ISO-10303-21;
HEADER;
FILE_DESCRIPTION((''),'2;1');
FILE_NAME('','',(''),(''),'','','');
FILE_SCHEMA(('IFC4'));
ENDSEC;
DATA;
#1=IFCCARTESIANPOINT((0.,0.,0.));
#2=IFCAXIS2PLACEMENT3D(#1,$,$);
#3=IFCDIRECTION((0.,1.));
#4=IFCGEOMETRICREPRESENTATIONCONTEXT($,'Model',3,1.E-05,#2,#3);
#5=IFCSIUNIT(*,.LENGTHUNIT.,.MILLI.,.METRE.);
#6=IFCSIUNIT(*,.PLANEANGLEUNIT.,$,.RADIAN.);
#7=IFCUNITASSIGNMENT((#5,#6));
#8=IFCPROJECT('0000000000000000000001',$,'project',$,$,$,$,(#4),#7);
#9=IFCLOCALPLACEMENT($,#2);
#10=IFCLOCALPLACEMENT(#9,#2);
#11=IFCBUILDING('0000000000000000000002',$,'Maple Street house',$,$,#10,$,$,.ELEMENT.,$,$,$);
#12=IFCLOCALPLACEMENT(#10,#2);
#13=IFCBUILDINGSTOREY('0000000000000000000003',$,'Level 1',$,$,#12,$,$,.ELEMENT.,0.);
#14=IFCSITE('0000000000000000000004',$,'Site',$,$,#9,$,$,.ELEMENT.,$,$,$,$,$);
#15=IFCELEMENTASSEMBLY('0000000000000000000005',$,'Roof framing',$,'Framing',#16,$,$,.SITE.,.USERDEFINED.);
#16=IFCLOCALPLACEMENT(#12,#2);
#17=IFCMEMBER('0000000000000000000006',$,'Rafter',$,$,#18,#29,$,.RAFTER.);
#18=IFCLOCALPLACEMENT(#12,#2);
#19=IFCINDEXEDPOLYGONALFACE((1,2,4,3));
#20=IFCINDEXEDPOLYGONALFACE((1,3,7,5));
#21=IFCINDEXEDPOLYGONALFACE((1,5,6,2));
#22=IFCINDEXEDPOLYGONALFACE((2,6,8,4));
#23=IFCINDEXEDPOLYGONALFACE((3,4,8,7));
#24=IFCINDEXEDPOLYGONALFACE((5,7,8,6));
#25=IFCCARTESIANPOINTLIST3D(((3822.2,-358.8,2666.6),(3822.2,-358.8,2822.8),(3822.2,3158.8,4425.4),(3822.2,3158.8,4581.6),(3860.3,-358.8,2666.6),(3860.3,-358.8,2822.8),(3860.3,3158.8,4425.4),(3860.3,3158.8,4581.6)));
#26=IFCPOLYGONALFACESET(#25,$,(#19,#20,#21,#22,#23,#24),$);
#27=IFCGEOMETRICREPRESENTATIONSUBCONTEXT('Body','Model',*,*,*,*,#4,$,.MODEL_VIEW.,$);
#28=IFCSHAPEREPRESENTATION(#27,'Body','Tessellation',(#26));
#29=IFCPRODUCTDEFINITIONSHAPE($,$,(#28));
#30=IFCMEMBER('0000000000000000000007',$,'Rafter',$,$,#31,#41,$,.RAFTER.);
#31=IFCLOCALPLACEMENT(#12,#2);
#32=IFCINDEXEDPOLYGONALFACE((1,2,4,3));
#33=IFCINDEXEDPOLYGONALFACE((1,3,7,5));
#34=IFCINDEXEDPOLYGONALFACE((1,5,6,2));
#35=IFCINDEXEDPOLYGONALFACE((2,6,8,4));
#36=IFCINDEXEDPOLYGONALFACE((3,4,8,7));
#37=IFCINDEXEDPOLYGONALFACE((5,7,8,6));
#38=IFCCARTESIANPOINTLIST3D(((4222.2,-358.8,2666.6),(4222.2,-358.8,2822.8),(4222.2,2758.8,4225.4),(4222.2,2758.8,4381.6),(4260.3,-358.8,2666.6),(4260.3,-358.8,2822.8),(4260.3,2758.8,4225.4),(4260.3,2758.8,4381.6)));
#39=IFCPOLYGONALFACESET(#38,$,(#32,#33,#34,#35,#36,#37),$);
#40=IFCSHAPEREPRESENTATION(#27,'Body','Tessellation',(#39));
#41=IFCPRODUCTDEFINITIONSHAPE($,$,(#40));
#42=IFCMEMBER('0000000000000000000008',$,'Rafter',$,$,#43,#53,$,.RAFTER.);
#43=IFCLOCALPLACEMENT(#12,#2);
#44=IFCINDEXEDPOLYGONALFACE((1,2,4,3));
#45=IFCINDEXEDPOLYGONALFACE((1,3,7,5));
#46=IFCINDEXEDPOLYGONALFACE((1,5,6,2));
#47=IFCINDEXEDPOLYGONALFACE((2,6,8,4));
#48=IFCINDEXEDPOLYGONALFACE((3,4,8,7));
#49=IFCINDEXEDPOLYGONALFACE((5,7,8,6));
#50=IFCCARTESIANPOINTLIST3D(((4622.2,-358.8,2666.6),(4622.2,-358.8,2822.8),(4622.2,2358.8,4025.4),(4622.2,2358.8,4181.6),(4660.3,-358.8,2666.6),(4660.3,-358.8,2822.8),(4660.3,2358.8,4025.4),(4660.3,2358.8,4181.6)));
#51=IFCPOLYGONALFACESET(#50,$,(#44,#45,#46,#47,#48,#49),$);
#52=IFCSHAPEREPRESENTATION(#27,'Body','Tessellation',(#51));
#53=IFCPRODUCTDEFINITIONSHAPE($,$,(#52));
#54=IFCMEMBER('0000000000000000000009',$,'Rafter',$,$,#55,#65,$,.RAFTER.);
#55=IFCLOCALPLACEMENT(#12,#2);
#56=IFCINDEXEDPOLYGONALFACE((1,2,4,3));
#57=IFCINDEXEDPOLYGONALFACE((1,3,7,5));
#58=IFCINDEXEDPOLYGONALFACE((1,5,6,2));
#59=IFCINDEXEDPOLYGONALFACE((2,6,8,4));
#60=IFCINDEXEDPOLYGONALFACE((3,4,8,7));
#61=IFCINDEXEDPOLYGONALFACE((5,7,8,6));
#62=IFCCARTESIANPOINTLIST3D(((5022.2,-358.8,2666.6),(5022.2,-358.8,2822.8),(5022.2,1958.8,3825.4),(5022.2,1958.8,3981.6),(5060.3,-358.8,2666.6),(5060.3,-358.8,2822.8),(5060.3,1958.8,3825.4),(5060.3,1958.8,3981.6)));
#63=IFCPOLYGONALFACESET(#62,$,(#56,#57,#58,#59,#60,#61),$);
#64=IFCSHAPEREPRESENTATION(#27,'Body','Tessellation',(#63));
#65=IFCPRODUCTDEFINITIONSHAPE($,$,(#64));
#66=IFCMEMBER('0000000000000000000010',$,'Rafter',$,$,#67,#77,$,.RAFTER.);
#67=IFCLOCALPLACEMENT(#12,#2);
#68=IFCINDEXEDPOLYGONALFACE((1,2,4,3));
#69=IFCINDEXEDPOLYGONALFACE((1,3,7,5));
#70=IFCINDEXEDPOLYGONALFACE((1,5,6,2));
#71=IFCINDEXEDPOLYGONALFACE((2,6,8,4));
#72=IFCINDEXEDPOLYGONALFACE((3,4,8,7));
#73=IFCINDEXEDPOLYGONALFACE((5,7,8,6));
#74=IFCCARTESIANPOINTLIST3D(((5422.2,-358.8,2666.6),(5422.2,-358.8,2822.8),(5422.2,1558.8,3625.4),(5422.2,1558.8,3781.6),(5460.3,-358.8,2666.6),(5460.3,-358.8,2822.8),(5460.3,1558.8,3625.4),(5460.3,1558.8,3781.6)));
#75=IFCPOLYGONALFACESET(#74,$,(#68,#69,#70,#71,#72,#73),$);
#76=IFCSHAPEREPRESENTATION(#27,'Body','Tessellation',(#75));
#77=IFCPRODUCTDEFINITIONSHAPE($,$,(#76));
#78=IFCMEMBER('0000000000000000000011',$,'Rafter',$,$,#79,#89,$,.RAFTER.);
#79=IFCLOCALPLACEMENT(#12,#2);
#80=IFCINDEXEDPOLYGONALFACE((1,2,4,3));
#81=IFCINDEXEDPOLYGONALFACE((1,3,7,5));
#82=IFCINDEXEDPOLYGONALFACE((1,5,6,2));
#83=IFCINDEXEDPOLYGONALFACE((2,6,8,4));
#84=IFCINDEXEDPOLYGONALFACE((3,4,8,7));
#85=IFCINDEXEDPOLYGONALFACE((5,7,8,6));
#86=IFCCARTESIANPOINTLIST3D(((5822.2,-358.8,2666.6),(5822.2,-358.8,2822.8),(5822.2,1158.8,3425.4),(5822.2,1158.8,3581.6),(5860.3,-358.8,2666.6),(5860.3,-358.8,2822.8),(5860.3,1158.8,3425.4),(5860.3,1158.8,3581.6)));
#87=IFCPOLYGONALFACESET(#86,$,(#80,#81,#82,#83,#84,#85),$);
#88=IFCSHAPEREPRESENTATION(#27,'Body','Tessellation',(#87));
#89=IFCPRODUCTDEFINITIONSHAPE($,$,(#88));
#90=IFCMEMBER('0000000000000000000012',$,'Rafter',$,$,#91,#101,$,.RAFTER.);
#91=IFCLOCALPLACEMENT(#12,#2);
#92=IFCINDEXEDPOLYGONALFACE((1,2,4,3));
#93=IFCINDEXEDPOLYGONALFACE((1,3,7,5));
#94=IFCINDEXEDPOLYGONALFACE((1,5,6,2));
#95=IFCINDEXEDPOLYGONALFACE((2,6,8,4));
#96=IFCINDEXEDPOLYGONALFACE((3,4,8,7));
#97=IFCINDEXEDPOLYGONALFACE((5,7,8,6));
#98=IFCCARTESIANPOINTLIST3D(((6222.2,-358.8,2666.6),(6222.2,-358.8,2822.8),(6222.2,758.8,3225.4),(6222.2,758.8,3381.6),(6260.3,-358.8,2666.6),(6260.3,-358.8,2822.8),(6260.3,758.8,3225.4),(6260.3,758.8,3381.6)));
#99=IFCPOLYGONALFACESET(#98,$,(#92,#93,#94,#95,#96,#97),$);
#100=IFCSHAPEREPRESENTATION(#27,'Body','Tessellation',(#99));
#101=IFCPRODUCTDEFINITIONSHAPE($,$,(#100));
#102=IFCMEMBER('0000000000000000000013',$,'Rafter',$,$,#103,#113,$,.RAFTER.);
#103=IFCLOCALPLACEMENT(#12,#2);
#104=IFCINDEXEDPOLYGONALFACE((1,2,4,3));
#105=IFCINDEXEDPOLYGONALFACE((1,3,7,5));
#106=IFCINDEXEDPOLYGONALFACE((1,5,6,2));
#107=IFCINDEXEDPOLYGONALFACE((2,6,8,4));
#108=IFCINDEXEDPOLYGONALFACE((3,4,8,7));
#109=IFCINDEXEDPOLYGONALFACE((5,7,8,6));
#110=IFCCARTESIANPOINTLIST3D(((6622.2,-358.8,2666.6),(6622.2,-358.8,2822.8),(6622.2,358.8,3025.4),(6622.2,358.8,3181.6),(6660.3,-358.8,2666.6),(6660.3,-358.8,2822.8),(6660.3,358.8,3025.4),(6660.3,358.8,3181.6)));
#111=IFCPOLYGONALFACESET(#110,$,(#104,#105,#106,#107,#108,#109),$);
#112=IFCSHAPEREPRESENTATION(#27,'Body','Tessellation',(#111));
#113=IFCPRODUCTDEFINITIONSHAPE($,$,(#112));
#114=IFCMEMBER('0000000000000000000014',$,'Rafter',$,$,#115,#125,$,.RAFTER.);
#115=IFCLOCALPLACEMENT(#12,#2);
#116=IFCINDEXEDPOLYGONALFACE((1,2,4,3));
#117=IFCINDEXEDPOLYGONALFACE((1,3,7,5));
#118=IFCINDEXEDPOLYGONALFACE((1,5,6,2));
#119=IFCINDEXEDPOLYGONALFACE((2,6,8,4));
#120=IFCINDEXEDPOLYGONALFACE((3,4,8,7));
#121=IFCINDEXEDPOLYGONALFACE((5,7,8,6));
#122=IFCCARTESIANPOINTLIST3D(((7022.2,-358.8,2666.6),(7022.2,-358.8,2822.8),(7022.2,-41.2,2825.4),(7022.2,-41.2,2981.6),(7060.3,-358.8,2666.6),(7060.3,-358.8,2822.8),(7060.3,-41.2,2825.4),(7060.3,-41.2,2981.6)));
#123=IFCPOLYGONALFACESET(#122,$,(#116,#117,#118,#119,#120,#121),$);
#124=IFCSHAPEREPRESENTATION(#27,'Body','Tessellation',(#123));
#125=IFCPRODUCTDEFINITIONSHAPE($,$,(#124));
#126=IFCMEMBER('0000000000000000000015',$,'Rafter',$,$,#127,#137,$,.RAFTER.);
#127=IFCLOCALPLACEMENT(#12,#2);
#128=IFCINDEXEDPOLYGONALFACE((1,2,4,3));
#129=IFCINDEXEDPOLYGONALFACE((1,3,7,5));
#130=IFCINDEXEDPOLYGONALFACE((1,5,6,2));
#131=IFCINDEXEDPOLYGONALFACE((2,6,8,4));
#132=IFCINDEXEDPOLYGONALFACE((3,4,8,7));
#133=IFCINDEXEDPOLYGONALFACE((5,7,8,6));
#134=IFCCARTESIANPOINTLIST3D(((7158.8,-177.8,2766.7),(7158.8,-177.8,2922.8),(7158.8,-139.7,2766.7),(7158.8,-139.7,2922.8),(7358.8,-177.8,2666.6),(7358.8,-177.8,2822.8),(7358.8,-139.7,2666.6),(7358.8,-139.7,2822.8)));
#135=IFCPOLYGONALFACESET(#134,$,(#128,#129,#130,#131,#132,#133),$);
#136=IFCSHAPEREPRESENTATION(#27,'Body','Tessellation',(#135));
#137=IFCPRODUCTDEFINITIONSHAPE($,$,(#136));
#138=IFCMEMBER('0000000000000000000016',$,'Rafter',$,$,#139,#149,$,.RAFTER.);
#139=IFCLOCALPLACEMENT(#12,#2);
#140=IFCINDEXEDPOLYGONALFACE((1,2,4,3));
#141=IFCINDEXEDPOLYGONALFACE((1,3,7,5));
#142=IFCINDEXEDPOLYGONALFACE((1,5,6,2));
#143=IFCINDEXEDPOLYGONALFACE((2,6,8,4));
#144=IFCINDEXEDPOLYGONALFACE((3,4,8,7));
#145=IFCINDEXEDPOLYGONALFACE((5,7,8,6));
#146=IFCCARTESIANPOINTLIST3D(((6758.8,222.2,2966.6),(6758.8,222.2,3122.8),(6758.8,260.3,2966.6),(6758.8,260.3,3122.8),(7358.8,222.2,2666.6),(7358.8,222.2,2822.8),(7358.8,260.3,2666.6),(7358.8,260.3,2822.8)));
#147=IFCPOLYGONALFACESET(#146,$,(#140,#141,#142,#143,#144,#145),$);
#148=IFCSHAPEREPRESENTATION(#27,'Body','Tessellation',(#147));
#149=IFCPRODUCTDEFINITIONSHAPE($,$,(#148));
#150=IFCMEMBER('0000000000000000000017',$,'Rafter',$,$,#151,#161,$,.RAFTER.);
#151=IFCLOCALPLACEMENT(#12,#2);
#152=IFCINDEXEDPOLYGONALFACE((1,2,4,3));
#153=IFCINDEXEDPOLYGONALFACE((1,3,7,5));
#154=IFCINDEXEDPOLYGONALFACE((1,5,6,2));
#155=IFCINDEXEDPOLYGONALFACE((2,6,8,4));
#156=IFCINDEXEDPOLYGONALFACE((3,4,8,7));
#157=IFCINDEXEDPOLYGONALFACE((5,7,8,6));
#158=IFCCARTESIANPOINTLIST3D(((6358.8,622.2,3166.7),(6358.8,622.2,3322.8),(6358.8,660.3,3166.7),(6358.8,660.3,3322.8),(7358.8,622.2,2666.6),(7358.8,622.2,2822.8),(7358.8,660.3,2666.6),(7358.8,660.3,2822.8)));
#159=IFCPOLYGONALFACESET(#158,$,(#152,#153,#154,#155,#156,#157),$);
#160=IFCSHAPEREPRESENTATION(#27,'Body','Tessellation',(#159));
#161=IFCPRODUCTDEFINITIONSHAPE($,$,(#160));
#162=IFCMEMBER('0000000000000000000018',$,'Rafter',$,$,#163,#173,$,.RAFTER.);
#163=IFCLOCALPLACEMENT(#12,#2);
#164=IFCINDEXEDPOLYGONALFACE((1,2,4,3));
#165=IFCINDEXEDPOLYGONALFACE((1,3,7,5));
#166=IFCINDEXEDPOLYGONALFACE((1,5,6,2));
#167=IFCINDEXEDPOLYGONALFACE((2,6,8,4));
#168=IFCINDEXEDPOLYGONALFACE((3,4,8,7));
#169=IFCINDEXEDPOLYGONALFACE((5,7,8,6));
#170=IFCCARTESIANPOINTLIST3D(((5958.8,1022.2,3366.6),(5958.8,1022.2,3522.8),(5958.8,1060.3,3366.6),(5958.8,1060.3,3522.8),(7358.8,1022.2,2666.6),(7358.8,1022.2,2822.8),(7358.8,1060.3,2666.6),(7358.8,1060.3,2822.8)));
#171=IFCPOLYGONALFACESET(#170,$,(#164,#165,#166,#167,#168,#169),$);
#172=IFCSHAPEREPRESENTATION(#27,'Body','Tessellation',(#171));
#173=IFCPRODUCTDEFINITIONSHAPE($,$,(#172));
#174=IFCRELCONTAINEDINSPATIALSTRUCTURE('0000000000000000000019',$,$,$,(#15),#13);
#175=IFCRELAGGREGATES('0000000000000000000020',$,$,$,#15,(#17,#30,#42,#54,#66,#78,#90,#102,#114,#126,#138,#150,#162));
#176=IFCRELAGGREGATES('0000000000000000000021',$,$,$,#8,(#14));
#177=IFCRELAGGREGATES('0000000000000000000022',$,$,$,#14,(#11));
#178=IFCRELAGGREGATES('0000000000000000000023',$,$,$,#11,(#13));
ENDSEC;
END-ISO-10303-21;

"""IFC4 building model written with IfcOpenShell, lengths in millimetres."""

from ifc_helpers import new_model, si_unit, direction, frame, origin, origin_with_axes, place, context, subcontext, project, spatial, polyline, outline, extrude, element, aggregate, save


model = new_model("IFC4")

# Units and contexts
model_context = context("Model", 3, precision=1e-05, world=origin(), true_north=direction((0.0, 1.0)))
body_context = subcontext(model_context, "Body", "Model", "MODEL_VIEW")
ifc_project = project(units=[si_unit("LENGTHUNIT", "METRE", prefix="MILLI"), si_unit("PLANEANGLEUNIT", "RADIAN")], contexts=[model_context])

# Site, building, storey
site_placement = place(None, origin())
site = spatial("IfcSite", under=ifc_project, at=site_placement, Name="Site", CompositionType="ELEMENT")
building_placement = place(site_placement, origin())
building = spatial("IfcBuilding", under=site, at=building_placement, Name="Maple Street house", CompositionType="ELEMENT")
storey_placement = place(building_placement, origin())
storey = spatial("IfcBuildingStorey", under=building, at=storey_placement, Name="Level 1", CompositionType="ELEMENT", Elevation=0.0)

# Element assembly, members
assembly_placement = place(storey_placement, origin_with_axes())
assembly = element("IfcElementAssembly", 1, at=assembly_placement, inside=storey, Name="Roof framing", ObjectType="Framing", AssemblyPlace="SITE", PredefinedType="USERDEFINED")
member_1_placement = place(storey_placement, origin_with_axes())
member_1 = element("IfcMember", 2, at=member_1_placement, Name="Rafter", PredefinedType="RAFTER", context=body_context, shape_type="SweptSolid", body=[
    extrude(outline(polyline([(0.0, 0.0), (38.1, 0.0), (38.1, 156.2), (0.0, 156.2), (0.0, 0.0)])), frame((3860.3, -358.8, 2666.7), z_axis=(0.0, 1.0, 0.0), x_axis=(-1.0, 0.0, 0.0)), (0.0, 0.447214, 0.894427), 3932.7),
])
member_2_placement = place(storey_placement, origin_with_axes())
member_2 = element("IfcMember", 3, at=member_2_placement, Name="Rafter", PredefinedType="RAFTER", context=body_context, shape_type="SweptSolid", body=[
    extrude(outline(polyline([(0.0, 0.0), (38.1, 0.0), (38.1, 156.2), (0.0, 156.2), (0.0, 0.0)])), frame((4260.3, -358.8, 2666.7), z_axis=(0.0, 1.0, 0.0), x_axis=(-1.0, 0.0, 0.0)), (0.0, 0.447214, 0.894427), 3485.5),
])
member_3_placement = place(storey_placement, origin_with_axes())
member_3 = element("IfcMember", 4, at=member_3_placement, Name="Rafter", PredefinedType="RAFTER", context=body_context, shape_type="SweptSolid", body=[
    extrude(outline(polyline([(0.0, 0.0), (38.1, 0.0), (38.1, 156.2), (0.0, 156.2), (0.0, 0.0)])), frame((4660.3, -358.8, 2666.7), z_axis=(0.0, 1.0, 0.0), x_axis=(-1.0, 0.0, 0.0)), (0.0, 0.447214, 0.894427), 3038.3),
])
member_4_placement = place(storey_placement, origin_with_axes())
member_4 = element("IfcMember", 5, at=member_4_placement, Name="Rafter", PredefinedType="RAFTER", context=body_context, shape_type="SweptSolid", body=[
    extrude(outline(polyline([(0.0, 0.0), (38.1, 0.0), (38.1, 156.2), (0.0, 156.2), (0.0, 0.0)])), frame((5060.3, -358.8, 2666.7), z_axis=(0.0, 1.0, 0.0), x_axis=(-1.0, 0.0, 0.0)), (0.0, 0.447214, 0.894427), 2591.1),
])
member_5_placement = place(storey_placement, origin_with_axes())
member_5 = element("IfcMember", 6, at=member_5_placement, Name="Rafter", PredefinedType="RAFTER", context=body_context, shape_type="SweptSolid", body=[
    extrude(outline(polyline([(0.0, 0.0), (38.1, 0.0), (38.1, 156.2), (0.0, 156.2), (0.0, 0.0)])), frame((5460.3, -358.8, 2666.7), z_axis=(0.0, 1.0, 0.0), x_axis=(-1.0, 0.0, 0.0)), (0.0, 0.447214, 0.894427), 2143.9),
])
member_6_placement = place(storey_placement, origin_with_axes())
member_6 = element("IfcMember", 7, at=member_6_placement, Name="Rafter", PredefinedType="RAFTER", context=body_context, shape_type="SweptSolid", body=[
    extrude(outline(polyline([(0.0, 0.0), (38.1, 0.0), (38.1, 156.2), (0.0, 156.2), (0.0, 0.0)])), frame((5860.3, -358.8, 2666.7), z_axis=(0.0, 1.0, 0.0), x_axis=(-1.0, 0.0, 0.0)), (0.0, 0.447214, 0.894427), 1696.7),
])
member_7_placement = place(storey_placement, origin_with_axes())
member_7 = element("IfcMember", 8, at=member_7_placement, Name="Rafter", PredefinedType="RAFTER", context=body_context, shape_type="SweptSolid", body=[
    extrude(outline(polyline([(0.0, 0.0), (38.1, 0.0), (38.1, 156.2), (0.0, 156.2), (0.0, 0.0)])), frame((6260.3, -358.8, 2666.7), z_axis=(0.0, 1.0, 0.0), x_axis=(-1.0, 0.0, 0.0)), (0.0, 0.447214, 0.894427), 1249.5),
])
member_8_placement = place(storey_placement, origin_with_axes())
member_8 = element("IfcMember", 9, at=member_8_placement, Name="Rafter", PredefinedType="RAFTER", context=body_context, shape_type="SweptSolid", body=[
    extrude(outline(polyline([(0.0, 0.0), (38.1, 0.0), (38.1, 156.2), (0.0, 156.2), (0.0, 0.0)])), frame((6660.3, -358.8, 2666.7), z_axis=(0.0, 1.0, 0.0), x_axis=(-1.0, 0.0, 0.0)), (0.0, 0.447214, 0.894427), 802.2),
])
member_9_placement = place(storey_placement, origin_with_axes())
member_9 = element("IfcMember", 10, at=member_9_placement, Name="Rafter", PredefinedType="RAFTER", context=body_context, shape_type="SweptSolid", body=[
    extrude(outline(polyline([(0.0, 0.0), (38.1, 0.0), (38.1, 156.2), (0.0, 156.2), (0.0, 0.0)])), frame((7060.3, -358.8, 2666.7), z_axis=(0.0, 1.0, 0.0), x_axis=(-1.0, 0.0, 0.0)), (0.0, 0.447214, 0.894427), 355.0),
])
member_10_placement = place(storey_placement, origin_with_axes())
member_10 = element("IfcMember", 11, at=member_10_placement, Name="Rafter", PredefinedType="RAFTER", context=body_context, shape_type="SweptSolid", body=[
    extrude(outline(polyline([(0.0, 0.0), (38.1, 0.0), (38.1, 156.2), (0.0, 156.2), (0.0, 0.0)])), frame((7358.8, -139.7, 2666.7), z_axis=(-1.0, 0.0, 0.0), x_axis=(0.0, -1.0, 0.0)), (0.0, 0.447214, 0.894427), 223.6),
])
member_11_placement = place(storey_placement, origin_with_axes())
member_11 = element("IfcMember", 12, at=member_11_placement, Name="Rafter", PredefinedType="RAFTER", context=body_context, shape_type="SweptSolid", body=[
    extrude(outline(polyline([(0.0, 0.0), (38.1, 0.0), (38.1, 156.2), (0.0, 156.2), (0.0, 0.0)])), frame((7358.8, 260.3, 2666.7), z_axis=(-1.0, 0.0, 0.0), x_axis=(0.0, -1.0, 0.0)), (0.0, 0.447214, 0.894427), 670.8),
])
member_12_placement = place(storey_placement, origin_with_axes())
member_12 = element("IfcMember", 13, at=member_12_placement, Name="Rafter", PredefinedType="RAFTER", context=body_context, shape_type="SweptSolid", body=[
    extrude(outline(polyline([(0.0, 0.0), (38.1, 0.0), (38.1, 156.2), (0.0, 156.2), (0.0, 0.0)])), frame((7358.8, 660.3, 2666.7), z_axis=(-1.0, 0.0, 0.0), x_axis=(0.0, -1.0, 0.0)), (0.0, 0.447214, 0.894427), 1118.0),
])
member_13_placement = place(storey_placement, origin_with_axes())
member_13 = element("IfcMember", 14, at=member_13_placement, Name="Rafter", PredefinedType="RAFTER", context=body_context, shape_type="SweptSolid", body=[
    extrude(outline(polyline([(0.0, 0.0), (38.1, 0.0), (38.1, 156.2), (0.0, 156.2), (0.0, 0.0)])), frame((7358.8, 1060.3, 2666.7), z_axis=(-1.0, 0.0, 0.0), x_axis=(0.0, -1.0, 0.0)), (0.0, 0.447214, 0.894427), 1565.2),
])
aggregate(assembly, [member_1, member_2, member_3, member_4, member_5, member_6, member_7, member_8, member_9, member_10, member_11, member_12, member_13])

save(model, "model.ifc")
